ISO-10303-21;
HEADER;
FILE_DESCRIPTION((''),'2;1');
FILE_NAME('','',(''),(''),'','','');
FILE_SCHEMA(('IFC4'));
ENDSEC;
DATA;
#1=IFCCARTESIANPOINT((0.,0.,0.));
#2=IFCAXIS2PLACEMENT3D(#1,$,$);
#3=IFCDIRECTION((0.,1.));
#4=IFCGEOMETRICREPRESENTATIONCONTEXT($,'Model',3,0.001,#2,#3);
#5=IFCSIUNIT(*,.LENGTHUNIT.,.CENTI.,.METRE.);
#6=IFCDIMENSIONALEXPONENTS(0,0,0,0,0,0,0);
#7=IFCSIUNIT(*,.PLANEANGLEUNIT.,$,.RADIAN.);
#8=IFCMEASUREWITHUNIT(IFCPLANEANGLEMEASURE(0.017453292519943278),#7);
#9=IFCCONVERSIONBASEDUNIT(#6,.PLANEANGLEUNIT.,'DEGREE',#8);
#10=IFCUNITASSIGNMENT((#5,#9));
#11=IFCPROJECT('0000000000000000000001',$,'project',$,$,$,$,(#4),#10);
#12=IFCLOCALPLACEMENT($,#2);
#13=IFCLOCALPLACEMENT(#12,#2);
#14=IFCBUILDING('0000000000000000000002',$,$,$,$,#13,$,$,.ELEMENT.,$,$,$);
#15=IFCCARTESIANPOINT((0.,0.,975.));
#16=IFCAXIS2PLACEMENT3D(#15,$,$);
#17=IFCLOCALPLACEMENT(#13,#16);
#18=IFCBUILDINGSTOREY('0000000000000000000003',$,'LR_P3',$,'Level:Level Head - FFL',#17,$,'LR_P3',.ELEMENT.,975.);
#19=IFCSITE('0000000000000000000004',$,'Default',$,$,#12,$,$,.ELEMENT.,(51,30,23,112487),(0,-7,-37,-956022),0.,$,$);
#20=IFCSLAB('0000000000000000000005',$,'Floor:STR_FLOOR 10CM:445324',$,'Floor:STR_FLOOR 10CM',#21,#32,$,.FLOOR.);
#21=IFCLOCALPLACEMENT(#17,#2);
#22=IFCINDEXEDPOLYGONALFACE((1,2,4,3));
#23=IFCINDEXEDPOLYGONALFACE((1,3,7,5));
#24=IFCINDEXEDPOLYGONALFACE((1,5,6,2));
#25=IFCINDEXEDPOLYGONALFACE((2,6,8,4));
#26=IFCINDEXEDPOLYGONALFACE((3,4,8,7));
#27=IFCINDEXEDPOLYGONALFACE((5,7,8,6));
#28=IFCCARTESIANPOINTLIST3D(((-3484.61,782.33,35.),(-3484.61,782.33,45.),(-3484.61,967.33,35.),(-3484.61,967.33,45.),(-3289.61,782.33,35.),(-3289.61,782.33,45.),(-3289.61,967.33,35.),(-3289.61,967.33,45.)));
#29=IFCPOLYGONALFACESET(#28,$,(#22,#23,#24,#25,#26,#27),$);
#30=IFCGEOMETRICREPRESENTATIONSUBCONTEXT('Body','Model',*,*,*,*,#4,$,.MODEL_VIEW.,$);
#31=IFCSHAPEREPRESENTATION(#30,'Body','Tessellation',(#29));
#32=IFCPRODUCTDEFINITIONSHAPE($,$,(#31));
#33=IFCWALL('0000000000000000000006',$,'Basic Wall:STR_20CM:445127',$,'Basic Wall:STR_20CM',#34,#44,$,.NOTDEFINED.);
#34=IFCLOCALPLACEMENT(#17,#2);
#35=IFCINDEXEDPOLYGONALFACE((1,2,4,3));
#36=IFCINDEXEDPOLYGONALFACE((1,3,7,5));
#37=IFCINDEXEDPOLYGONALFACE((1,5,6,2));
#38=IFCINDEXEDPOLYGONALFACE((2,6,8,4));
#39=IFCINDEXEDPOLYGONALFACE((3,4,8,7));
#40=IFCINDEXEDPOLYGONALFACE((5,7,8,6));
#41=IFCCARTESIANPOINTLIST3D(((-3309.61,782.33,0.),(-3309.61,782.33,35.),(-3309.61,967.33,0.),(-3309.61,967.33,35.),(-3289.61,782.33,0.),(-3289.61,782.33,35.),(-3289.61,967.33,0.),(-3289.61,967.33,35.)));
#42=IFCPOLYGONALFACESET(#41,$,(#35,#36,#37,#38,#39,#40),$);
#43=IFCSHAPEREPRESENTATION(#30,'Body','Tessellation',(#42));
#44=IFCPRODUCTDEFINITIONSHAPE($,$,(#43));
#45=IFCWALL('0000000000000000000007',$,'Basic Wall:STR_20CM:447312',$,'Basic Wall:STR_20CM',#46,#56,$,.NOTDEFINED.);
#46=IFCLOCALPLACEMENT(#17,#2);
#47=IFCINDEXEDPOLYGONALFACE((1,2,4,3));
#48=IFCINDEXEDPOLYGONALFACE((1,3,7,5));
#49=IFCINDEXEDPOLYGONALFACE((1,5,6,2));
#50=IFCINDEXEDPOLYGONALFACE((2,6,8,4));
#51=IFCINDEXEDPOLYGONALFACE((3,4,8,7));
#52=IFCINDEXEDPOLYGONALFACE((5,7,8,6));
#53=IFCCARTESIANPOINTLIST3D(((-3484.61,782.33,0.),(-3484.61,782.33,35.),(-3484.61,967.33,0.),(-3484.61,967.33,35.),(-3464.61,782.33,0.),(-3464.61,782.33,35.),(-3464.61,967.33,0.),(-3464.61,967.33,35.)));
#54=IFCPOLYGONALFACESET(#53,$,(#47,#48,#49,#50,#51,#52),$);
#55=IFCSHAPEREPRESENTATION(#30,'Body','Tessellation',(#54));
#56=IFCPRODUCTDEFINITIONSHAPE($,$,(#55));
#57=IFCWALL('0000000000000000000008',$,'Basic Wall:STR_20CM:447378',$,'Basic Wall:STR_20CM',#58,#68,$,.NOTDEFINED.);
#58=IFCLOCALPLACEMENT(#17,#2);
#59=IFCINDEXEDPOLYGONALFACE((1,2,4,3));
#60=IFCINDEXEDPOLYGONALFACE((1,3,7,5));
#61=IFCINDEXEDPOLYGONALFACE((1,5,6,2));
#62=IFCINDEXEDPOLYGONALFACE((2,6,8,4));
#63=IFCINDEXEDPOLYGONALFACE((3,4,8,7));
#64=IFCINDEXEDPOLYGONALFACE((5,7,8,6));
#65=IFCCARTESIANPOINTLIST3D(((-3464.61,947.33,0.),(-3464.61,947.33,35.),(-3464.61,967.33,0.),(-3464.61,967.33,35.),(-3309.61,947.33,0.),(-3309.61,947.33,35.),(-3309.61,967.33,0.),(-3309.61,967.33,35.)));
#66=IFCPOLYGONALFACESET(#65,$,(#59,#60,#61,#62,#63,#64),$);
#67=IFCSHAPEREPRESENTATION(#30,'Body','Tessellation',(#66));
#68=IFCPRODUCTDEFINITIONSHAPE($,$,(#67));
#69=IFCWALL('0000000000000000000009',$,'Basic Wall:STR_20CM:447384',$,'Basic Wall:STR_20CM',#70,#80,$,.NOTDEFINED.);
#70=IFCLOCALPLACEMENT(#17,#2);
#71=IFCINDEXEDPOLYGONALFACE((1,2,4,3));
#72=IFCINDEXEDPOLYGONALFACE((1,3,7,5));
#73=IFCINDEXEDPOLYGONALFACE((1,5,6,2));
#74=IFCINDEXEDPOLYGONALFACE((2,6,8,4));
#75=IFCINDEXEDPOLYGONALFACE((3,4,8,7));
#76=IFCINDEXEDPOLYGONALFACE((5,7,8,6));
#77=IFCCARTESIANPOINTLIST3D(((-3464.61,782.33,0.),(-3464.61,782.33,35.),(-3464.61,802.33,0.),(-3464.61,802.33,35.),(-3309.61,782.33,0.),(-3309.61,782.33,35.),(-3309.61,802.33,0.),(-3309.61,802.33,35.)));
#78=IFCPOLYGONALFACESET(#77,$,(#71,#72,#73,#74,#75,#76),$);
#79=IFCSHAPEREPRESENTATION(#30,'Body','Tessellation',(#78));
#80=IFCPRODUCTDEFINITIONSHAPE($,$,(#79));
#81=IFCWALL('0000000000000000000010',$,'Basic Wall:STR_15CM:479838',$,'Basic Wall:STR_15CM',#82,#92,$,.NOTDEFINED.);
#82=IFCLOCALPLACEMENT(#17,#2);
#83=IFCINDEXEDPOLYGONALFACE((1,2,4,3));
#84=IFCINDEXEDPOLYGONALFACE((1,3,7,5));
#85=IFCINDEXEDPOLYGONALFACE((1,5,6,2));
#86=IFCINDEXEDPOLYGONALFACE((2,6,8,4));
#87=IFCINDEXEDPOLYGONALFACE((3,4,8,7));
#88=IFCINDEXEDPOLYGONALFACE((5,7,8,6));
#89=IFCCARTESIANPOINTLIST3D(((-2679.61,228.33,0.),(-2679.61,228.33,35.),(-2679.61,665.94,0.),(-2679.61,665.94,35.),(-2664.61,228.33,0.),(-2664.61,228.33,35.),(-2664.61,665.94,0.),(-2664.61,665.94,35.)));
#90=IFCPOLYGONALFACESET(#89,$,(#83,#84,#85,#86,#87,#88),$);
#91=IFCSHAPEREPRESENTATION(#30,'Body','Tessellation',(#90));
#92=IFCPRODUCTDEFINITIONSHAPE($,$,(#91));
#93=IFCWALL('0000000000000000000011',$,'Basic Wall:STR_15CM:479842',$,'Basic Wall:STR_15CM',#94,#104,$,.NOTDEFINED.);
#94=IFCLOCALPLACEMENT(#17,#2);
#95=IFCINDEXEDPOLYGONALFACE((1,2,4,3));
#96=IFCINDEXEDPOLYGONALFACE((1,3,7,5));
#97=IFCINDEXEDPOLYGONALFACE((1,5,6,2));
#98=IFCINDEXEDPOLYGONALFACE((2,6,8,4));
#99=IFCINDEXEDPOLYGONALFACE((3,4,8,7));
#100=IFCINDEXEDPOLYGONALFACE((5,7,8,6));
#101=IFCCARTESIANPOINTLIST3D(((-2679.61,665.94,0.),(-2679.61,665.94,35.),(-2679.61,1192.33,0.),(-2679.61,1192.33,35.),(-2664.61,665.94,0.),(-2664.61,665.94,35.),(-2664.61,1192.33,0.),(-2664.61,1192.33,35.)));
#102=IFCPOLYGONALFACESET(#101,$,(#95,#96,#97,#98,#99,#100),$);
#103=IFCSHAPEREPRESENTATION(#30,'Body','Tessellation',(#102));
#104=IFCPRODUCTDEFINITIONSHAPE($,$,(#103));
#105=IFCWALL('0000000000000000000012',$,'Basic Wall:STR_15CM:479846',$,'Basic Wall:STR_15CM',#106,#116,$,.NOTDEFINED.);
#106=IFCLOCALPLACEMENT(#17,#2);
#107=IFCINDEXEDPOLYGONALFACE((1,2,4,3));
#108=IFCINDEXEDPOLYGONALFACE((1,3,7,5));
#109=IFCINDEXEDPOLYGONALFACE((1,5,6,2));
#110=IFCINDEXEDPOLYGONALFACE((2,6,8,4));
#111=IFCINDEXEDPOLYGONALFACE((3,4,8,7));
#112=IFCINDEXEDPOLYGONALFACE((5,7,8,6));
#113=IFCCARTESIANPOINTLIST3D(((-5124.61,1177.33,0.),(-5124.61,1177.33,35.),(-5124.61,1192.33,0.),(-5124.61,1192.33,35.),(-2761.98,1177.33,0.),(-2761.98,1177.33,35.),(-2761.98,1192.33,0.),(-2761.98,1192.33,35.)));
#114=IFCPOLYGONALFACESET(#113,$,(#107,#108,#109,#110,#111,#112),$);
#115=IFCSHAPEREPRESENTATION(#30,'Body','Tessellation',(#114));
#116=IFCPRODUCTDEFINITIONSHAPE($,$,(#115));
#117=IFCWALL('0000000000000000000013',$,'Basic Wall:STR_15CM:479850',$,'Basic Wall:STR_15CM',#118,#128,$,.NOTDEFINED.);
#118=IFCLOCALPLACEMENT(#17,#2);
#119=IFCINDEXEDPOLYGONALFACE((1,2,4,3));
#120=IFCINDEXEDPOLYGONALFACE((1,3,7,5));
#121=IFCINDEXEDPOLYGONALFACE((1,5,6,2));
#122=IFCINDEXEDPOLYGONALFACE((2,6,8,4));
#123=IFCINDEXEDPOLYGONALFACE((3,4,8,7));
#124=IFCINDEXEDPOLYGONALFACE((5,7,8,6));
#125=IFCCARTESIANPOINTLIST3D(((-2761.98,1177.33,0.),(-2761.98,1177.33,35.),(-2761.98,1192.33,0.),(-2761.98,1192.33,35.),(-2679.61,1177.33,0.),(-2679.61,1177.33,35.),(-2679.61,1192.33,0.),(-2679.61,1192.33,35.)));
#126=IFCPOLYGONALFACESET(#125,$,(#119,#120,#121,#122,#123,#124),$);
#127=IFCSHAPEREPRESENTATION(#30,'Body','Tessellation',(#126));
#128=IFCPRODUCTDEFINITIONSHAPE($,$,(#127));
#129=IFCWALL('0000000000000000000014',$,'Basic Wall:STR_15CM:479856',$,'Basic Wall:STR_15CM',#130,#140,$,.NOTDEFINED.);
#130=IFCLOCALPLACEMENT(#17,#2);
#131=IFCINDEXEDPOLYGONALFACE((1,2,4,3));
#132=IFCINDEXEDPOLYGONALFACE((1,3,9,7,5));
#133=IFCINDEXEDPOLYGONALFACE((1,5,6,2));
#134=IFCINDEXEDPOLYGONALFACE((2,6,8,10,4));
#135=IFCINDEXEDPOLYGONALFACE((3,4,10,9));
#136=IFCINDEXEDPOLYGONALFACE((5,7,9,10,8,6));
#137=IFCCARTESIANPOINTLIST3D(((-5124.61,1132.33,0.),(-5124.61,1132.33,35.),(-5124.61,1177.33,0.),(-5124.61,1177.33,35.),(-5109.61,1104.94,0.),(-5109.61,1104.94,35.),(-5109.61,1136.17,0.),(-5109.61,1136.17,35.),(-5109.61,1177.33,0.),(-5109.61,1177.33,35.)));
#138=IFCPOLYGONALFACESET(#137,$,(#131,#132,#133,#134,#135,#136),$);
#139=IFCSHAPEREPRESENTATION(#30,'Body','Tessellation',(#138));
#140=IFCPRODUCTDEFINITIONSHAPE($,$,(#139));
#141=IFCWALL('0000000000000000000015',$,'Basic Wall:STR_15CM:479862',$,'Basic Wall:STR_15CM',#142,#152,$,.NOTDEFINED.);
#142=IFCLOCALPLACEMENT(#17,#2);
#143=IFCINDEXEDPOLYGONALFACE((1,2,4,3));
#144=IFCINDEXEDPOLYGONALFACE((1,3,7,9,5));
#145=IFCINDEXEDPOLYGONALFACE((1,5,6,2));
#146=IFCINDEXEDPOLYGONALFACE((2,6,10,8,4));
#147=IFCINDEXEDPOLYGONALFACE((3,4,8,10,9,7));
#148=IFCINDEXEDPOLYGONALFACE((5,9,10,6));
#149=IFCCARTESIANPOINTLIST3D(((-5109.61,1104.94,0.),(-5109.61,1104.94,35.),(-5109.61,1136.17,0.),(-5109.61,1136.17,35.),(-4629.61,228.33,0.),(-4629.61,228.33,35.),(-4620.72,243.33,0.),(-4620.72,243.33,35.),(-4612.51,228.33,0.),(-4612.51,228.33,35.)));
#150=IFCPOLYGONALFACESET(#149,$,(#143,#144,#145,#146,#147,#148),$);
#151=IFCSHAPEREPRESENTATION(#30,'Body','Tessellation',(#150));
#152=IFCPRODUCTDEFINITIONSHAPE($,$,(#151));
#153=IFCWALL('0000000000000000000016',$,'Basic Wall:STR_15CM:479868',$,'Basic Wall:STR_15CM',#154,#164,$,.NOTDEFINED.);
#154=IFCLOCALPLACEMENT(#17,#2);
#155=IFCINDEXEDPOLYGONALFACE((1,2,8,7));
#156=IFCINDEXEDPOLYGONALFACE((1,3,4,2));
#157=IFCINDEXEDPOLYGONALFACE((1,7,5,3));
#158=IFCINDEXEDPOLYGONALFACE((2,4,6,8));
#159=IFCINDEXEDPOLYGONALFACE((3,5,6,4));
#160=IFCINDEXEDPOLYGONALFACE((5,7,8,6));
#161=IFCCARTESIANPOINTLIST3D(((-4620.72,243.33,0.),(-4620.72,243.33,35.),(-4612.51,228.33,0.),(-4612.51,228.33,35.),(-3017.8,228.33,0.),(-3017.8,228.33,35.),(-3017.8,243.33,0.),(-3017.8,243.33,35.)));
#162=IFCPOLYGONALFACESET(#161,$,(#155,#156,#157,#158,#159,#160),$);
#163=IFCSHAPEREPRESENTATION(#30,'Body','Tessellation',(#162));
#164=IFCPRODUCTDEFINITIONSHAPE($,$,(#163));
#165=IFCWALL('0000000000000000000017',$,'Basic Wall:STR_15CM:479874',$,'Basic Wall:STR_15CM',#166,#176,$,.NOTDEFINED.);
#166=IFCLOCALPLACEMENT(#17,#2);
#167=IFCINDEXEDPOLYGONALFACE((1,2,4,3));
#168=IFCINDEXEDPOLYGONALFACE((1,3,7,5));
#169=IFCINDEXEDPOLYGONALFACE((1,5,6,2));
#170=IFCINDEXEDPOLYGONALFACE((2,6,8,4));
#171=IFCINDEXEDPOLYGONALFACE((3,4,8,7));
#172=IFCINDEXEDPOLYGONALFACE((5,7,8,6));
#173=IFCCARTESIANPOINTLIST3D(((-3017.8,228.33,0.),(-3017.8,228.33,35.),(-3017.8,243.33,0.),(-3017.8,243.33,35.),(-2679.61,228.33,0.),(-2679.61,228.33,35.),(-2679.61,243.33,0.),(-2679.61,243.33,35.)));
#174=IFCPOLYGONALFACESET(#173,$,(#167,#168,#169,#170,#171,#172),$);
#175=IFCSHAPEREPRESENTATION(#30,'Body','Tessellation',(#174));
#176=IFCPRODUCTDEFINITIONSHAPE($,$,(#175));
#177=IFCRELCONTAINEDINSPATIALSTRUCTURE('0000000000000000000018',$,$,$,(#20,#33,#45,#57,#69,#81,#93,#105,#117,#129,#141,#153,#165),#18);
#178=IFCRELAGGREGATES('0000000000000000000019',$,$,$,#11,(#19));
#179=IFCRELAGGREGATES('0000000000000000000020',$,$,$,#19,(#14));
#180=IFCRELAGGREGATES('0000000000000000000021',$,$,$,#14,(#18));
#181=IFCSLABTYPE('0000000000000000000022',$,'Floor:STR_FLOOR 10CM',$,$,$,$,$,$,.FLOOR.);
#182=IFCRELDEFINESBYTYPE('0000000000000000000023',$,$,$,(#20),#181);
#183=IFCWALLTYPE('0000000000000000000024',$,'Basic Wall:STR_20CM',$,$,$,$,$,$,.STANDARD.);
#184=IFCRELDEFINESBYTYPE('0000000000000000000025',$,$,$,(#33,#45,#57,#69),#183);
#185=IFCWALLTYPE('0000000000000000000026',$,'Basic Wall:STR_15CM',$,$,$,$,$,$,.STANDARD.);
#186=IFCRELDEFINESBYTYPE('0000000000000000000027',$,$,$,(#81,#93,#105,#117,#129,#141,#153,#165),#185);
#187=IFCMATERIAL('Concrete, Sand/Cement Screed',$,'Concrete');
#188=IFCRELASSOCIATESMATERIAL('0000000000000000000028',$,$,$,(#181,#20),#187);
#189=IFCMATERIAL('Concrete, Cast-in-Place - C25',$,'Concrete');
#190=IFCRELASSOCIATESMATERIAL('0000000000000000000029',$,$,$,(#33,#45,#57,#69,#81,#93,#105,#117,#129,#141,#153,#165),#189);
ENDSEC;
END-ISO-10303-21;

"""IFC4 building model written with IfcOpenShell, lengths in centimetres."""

from ifc_helpers import new_model, entity, si_unit, converted_unit, direction, frame, origin, place, context, subcontext, project, spatial, indexed_curve, outline, extrude, material, type_object, element, save


model = new_model("IFC4")

# Units and contexts
model_context = context("Model", 3, precision=0.001, world=origin(), true_north=direction((0.0, 1.0)))
body_context = subcontext(model_context, "Body", "Model", "MODEL_VIEW")
ifc_project = project(units=[si_unit("LENGTHUNIT", "METRE", prefix="CENTI"), converted_unit("PLANEANGLEUNIT", "DEGREE", entity("IfcPlaneAngleMeasure", 0.017453292519943278), si_unit("PLANEANGLEUNIT", "RADIAN"), dimensions=[0, 0, 0, 0, 0, 0, 0])], contexts=[model_context])

# Site, building, storey
site_placement = place(None, origin())
site = spatial("IfcSite", under=ifc_project, at=site_placement, Name="Default", CompositionType="ELEMENT", RefLatitude=(51, 30, 23, 112487), RefLongitude=(0, -7, -37, -956022), RefElevation=0.0)
building_placement = place(site_placement, origin())
building = spatial("IfcBuilding", under=site, at=building_placement, CompositionType="ELEMENT")
storey_placement = place(building_placement, frame((0.0, 0.0, 975.0)))
storey = spatial("IfcBuildingStorey", under=building, at=storey_placement, Name="LR_P3", ObjectType="Level:Level Head - FFL", LongName="LR_P3", CompositionType="ELEMENT", Elevation=975.0)

# Slab
ifc_material_1 = material(Name="Concrete, Sand/Cement Screed", Category="Concrete")
slab_type_1 = type_object("IfcSlabType", Name="Floor:STR_FLOOR 10CM", PredefinedType="FLOOR", material=ifc_material_1)
slab_1_placement = place(storey_placement, origin())
element("IfcSlab", 1, at=slab_1_placement, inside=storey, type_object=slab_type_1, material=ifc_material_1, Name="Floor:STR_FLOOR 10CM:445324", ObjectType="Floor:STR_FLOOR 10CM", PredefinedType="FLOOR", context=body_context, shape_type="SweptSolid", body=[
    extrude(outline(indexed_curve([(-92.5, -97.5), (92.5, -97.5), (92.5, 97.5), (-92.5, 97.5), (-92.5, -97.5)], self_intersect=False)), frame((-3387.11, 874.83, 45.0), z_axis=(0.0, 0.0, -1.0), x_axis=(0.0, 1.0, 0.0)), (0.0, 0.0, 1.0), 10.0),
])

# Walls
ifc_material_2 = material(Name="Concrete, Cast-in-Place - C25", Category="Concrete")
wall_type_1 = type_object("IfcWallType", Name="Basic Wall:STR_20CM", PredefinedType="STANDARD")
wall_1_placement = place(storey_placement, frame((-3299.61, 782.33, 0.0), z_axis=(0.0, 0.0, 1.0), x_axis=(0.0, 1.0, 0.0)))
element("IfcWall", 2, at=wall_1_placement, inside=storey, type_object=wall_type_1, material=ifc_material_2, Name="Basic Wall:STR_20CM:445127", ObjectType="Basic Wall:STR_20CM", PredefinedType="NOTDEFINED", context=body_context, shape_type="SweptSolid", body=[
    extrude(outline(indexed_curve([(185.0, 10.0), (0.0, 10.0), (0.0, -10.0), (185.0, -10.0), (185.0, 10.0)], self_intersect=False)), origin(), (0.0, 0.0, 1.0), 35.0),
])
wall_2_placement = place(storey_placement, frame((-3474.61, 782.33, 0.0), z_axis=(0.0, 0.0, 1.0), x_axis=(0.0, 1.0, 0.0)))
element("IfcWall", 3, at=wall_2_placement, inside=storey, type_object=wall_type_1, material=ifc_material_2, Name="Basic Wall:STR_20CM:447312", ObjectType="Basic Wall:STR_20CM", PredefinedType="NOTDEFINED", context=body_context, shape_type="SweptSolid", body=[
    extrude(outline(indexed_curve([(185.0, 10.0), (0.0, 10.0), (0.0, -10.0), (185.0, -10.0), (185.0, 10.0)], self_intersect=False)), origin(), (0.0, 0.0, 1.0), 35.0),
])
wall_3_placement = place(storey_placement, frame((-3309.61, 957.33, 0.0), z_axis=(0.0, 0.0, 1.0), x_axis=(-1.0, 0.0, 0.0)))
element("IfcWall", 4, at=wall_3_placement, inside=storey, type_object=wall_type_1, material=ifc_material_2, Name="Basic Wall:STR_20CM:447378", ObjectType="Basic Wall:STR_20CM", PredefinedType="NOTDEFINED", context=body_context, shape_type="SweptSolid", body=[
    extrude(outline(indexed_curve([(155.0, 10.0), (0.0, 10.0), (0.0, -10.0), (155.0, -10.0), (155.0, 10.0)], self_intersect=False)), origin(), (0.0, 0.0, 1.0), 35.0),
])
wall_4_placement = place(storey_placement, frame((-3309.61, 792.33, 0.0), z_axis=(0.0, 0.0, 1.0), x_axis=(-1.0, 0.0, 0.0)))
element("IfcWall", 5, at=wall_4_placement, inside=storey, type_object=wall_type_1, material=ifc_material_2, Name="Basic Wall:STR_20CM:447384", ObjectType="Basic Wall:STR_20CM", PredefinedType="NOTDEFINED", context=body_context, shape_type="SweptSolid", body=[
    extrude(outline(indexed_curve([(155.0, 10.0), (0.0, 10.0), (0.0, -10.0), (155.0, -10.0), (155.0, 10.0)], self_intersect=False)), origin(), (0.0, 0.0, 1.0), 35.0),
])
wall_type_2 = type_object("IfcWallType", Name="Basic Wall:STR_15CM", PredefinedType="STANDARD")
wall_5_placement = place(storey_placement, frame((-2672.11, 665.94, 0.0), z_axis=(0.0, 0.0, 1.0), x_axis=(0.0, -1.0, 0.0)))
element("IfcWall", 6, at=wall_5_placement, inside=storey, type_object=wall_type_2, material=ifc_material_2, Name="Basic Wall:STR_15CM:479838", ObjectType="Basic Wall:STR_15CM", PredefinedType="NOTDEFINED", context=body_context, shape_type="SweptSolid", body=[
    extrude(outline(indexed_curve([(437.61, 7.5), (0.0, 7.5), (0.0, -7.5), (437.61, -7.5), (437.61, 7.5)], self_intersect=False)), origin(), (0.0, 0.0, 1.0), 35.0),
])
wall_6_placement = place(storey_placement, frame((-2672.11, 1192.33, 0.0), z_axis=(0.0, 0.0, 1.0), x_axis=(0.0, -1.0, 0.0)))
element("IfcWall", 7, at=wall_6_placement, inside=storey, type_object=wall_type_2, material=ifc_material_2, Name="Basic Wall:STR_15CM:479842", ObjectType="Basic Wall:STR_15CM", PredefinedType="NOTDEFINED", context=body_context, shape_type="SweptSolid", body=[
    extrude(outline(indexed_curve([(526.39, 7.5), (0.0, 7.5), (0.0, -7.5), (526.39, -7.5), (526.39, 7.5)], self_intersect=False)), origin(), (0.0, 0.0, 1.0), 35.0),
])
wall_7_placement = place(storey_placement, frame((-5124.61, 1184.83, 0.0)))
element("IfcWall", 8, at=wall_7_placement, inside=storey, type_object=wall_type_2, material=ifc_material_2, Name="Basic Wall:STR_15CM:479846", ObjectType="Basic Wall:STR_15CM", PredefinedType="NOTDEFINED", context=body_context, shape_type="SweptSolid", body=[
    extrude(outline(indexed_curve([(2362.64, 7.5), (0.0, 7.5), (0.0, -7.5), (2362.64, -7.5), (2362.64, 7.5)], self_intersect=False)), origin(), (0.0, 0.0, 1.0), 35.0),
])
wall_8_placement = place(storey_placement, frame((-2761.98, 1184.83, 0.0)))
element("IfcWall", 9, at=wall_8_placement, inside=storey, type_object=wall_type_2, material=ifc_material_2, Name="Basic Wall:STR_15CM:479850", ObjectType="Basic Wall:STR_15CM", PredefinedType="NOTDEFINED", context=body_context, shape_type="SweptSolid", body=[
    extrude(outline(indexed_curve([(82.36, 7.5), (0.0, 7.5), (0.0, -7.5), (82.36, -7.5), (82.36, 7.5)], self_intersect=False)), origin(), (0.0, 0.0, 1.0), 35.0),
])
wall_9_placement = place(storey_placement, frame((-5117.11, 1104.94, 0.0), z_axis=(0.0, 0.0, 1.0), x_axis=(0.0, 1.0, 0.0)))
element("IfcWall", 10, at=wall_9_placement, inside=storey, type_object=wall_type_2, material=ifc_material_2, Name="Basic Wall:STR_15CM:479856", ObjectType="Basic Wall:STR_15CM", PredefinedType="NOTDEFINED", context=body_context, shape_type="SweptSolid", body=[
    extrude(outline(indexed_curve([(72.39, -7.5), (72.39, 7.5), (27.39, 7.5), (0.0, -7.5), (31.23, -7.5), (72.39, -7.5)], self_intersect=False)), origin(), (0.0, 0.0, 1.0), 35.0),
])
wall_10_placement = place(storey_placement, frame((-4619.09, 224.73, 0.0), z_axis=(0.0, 0.0, 1.0), x_axis=(-0.480279, 0.877116, 0.0)))
element("IfcWall", 11, at=wall_10_placement, inside=storey, type_object=wall_type_2, material=ifc_material_2, Name="Basic Wall:STR_15CM:479862", ObjectType="Basic Wall:STR_15CM", PredefinedType="NOTDEFINED", context=body_context, shape_type="SweptSolid", body=[
    extrude(outline(indexed_curve([(1035.03, -7.5), (1007.63, 7.5), (8.21, 7.5), (0.0, -7.5), (17.1, -7.5), (1035.03, -7.5)], self_intersect=False)), origin(), (0.0, 0.0, 1.0), 35.0),
])
wall_11_placement = place(storey_placement, frame((-3017.8, 235.83, 0.0), z_axis=(0.0, 0.0, 1.0), x_axis=(-1.0, 0.0, 0.0)))
element("IfcWall", 12, at=wall_11_placement, inside=storey, type_object=wall_type_2, material=ifc_material_2, Name="Basic Wall:STR_15CM:479868", ObjectType="Basic Wall:STR_15CM", PredefinedType="NOTDEFINED", context=body_context, shape_type="SweptSolid", body=[
    extrude(outline(indexed_curve([(1602.93, -7.5), (1594.71, 7.5), (0.0, 7.5), (0.0, -7.5), (1602.93, -7.5)], self_intersect=False)), origin(), (0.0, 0.0, 1.0), 35.0),
])
wall_12_placement = place(storey_placement, frame((-2679.61, 235.83, 0.0), z_axis=(0.0, 0.0, 1.0), x_axis=(-1.0, 0.0, 0.0)))
element("IfcWall", 13, at=wall_12_placement, inside=storey, type_object=wall_type_2, material=ifc_material_2, Name="Basic Wall:STR_15CM:479874", ObjectType="Basic Wall:STR_15CM", PredefinedType="NOTDEFINED", context=body_context, shape_type="SweptSolid", body=[
    extrude(outline(indexed_curve([(338.18, 7.5), (0.0, 7.5), (0.0, -7.5), (338.18, -7.5), (338.18, 7.5)], self_intersect=False)), origin(), (0.0, 0.0, 1.0), 35.0),
])

save(model, "model.ifc")
